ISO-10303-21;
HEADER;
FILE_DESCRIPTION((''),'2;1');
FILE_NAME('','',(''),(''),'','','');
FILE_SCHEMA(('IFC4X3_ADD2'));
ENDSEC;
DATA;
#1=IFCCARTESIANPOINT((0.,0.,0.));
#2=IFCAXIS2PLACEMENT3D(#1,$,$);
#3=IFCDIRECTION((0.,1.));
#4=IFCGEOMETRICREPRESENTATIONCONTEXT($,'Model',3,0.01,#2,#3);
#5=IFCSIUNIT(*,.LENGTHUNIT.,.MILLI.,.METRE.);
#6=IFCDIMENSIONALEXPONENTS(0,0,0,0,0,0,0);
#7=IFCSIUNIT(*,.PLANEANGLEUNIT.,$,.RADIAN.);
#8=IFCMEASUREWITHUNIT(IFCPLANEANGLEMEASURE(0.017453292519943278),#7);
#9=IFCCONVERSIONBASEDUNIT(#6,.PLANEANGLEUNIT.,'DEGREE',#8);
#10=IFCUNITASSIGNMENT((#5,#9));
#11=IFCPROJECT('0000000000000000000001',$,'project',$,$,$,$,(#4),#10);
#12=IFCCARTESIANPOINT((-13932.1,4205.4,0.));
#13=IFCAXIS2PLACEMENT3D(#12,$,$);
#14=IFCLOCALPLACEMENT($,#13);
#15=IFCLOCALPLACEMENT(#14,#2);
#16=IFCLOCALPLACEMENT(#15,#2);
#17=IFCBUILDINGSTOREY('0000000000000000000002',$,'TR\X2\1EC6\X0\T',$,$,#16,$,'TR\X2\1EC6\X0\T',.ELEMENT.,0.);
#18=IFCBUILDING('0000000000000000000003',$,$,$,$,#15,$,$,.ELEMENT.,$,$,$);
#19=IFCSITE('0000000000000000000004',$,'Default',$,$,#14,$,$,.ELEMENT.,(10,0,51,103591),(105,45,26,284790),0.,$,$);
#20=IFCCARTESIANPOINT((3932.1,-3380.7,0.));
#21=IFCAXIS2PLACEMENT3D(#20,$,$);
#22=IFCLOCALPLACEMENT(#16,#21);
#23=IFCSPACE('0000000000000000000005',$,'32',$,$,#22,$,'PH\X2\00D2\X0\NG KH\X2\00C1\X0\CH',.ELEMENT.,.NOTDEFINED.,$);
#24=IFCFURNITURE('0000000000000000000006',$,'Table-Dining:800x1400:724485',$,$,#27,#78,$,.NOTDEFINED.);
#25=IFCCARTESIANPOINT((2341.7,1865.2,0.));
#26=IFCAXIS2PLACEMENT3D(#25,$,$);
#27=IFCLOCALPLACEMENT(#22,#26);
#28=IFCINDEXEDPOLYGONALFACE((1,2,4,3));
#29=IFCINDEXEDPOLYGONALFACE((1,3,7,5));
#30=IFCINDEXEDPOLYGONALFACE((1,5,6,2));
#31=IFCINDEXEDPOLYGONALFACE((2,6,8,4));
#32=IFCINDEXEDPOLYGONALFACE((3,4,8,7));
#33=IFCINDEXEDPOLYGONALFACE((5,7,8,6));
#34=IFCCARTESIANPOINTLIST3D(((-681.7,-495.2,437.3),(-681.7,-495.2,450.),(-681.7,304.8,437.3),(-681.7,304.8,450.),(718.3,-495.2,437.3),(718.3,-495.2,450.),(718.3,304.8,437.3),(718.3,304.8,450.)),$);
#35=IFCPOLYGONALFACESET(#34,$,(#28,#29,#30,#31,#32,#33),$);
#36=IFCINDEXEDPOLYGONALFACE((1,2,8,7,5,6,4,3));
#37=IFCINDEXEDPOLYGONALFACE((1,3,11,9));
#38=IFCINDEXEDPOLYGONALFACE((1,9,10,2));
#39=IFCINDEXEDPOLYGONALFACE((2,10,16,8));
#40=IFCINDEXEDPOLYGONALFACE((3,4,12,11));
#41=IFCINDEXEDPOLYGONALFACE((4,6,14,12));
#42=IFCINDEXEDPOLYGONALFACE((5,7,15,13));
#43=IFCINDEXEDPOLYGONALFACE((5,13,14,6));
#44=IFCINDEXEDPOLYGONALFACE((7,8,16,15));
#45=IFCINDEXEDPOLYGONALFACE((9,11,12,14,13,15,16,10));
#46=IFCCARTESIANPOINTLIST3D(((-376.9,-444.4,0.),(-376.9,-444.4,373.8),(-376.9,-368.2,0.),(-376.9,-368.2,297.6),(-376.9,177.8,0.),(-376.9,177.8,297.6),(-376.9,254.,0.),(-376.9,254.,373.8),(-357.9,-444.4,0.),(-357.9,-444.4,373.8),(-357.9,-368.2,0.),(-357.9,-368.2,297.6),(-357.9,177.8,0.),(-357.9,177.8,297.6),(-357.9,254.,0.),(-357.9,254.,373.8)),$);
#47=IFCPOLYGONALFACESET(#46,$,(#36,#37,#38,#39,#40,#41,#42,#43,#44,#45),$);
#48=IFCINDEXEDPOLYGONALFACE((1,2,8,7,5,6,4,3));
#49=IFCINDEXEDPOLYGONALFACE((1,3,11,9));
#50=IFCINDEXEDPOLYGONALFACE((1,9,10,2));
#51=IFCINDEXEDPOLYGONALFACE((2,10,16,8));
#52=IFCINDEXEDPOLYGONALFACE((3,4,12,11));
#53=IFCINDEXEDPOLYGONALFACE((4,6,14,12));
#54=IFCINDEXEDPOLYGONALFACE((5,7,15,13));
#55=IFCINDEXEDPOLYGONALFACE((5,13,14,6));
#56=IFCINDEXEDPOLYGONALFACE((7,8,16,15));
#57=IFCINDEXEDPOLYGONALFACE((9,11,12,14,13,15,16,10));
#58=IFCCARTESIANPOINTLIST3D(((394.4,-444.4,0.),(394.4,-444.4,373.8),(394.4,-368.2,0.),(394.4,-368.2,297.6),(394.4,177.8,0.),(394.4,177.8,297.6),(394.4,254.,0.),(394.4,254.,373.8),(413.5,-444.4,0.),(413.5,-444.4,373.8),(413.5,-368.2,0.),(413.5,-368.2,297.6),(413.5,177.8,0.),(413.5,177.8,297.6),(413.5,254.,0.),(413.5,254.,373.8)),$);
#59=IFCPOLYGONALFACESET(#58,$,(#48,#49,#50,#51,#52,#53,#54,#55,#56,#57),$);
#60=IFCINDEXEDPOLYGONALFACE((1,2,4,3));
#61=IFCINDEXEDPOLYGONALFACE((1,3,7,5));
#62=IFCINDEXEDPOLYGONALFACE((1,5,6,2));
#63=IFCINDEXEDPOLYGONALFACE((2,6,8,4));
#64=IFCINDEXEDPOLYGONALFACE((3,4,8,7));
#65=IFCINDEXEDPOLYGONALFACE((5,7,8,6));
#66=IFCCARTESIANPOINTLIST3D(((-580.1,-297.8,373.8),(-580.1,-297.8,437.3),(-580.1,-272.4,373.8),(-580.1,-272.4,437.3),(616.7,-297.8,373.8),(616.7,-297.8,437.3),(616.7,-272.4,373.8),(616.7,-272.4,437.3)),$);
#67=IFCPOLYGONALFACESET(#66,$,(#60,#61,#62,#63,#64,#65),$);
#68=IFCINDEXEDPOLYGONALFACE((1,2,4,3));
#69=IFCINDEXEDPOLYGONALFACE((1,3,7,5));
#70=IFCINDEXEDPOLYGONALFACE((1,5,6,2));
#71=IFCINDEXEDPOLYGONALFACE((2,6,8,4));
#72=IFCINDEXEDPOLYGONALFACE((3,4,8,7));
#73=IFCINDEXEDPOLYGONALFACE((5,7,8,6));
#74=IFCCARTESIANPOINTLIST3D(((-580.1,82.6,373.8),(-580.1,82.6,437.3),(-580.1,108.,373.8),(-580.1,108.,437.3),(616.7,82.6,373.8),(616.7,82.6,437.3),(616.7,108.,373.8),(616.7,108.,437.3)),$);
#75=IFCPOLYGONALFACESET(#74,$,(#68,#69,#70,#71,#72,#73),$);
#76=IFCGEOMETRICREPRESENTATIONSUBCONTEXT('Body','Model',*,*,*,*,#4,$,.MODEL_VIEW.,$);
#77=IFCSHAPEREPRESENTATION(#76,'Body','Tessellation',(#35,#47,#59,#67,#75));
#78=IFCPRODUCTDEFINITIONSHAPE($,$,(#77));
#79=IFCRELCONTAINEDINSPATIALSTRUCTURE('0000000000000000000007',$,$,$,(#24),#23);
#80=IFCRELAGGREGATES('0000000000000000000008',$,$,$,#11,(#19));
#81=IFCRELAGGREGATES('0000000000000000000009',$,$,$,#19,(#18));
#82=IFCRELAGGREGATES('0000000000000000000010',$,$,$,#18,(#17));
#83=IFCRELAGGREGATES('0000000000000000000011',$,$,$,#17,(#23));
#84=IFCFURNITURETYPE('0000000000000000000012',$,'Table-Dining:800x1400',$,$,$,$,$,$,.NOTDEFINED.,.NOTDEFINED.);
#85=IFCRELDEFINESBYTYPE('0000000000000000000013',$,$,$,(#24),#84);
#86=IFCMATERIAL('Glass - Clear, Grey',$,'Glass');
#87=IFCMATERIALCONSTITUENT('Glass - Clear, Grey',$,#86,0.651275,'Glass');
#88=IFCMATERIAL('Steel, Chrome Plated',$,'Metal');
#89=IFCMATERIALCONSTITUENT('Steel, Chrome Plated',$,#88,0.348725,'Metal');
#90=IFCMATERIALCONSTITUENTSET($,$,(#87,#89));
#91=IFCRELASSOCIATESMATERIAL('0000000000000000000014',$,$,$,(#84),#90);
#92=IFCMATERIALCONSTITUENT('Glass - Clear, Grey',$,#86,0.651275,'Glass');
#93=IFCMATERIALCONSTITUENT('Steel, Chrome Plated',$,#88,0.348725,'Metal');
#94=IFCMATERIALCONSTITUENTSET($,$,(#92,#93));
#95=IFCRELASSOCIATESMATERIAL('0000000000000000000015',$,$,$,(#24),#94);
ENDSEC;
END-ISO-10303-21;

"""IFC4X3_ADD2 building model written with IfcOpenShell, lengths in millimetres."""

from ifc_helpers import new_model, entity, si_unit, converted_unit, direction, frame, frame_2d, origin, origin_2d_with_axis, place, context, subcontext, project, spatial, polyline, rectangle, outline, extrude, source, transform, mapped, material, constituent, constituent_set, type_object, type_shapes, element, save


model = new_model("IFC4X3_ADD2")

# Units and contexts
model_context = context("Model", 3, precision=0.01, world=origin(), true_north=direction((0.0, 1.0)))
body_context = subcontext(model_context, "Body", "Model", "MODEL_VIEW")
ifc_project = project(units=[si_unit("LENGTHUNIT", "METRE", prefix="MILLI"), converted_unit("PLANEANGLEUNIT", "DEGREE", entity("IfcPlaneAngleMeasure", 0.017453292519943278), si_unit("PLANEANGLEUNIT", "RADIAN"), dimensions=[0, 0, 0, 0, 0, 0, 0])], contexts=[model_context])

# Site, building, storey
site_placement = place(None, frame((-13932.1, 4205.4, 0.0)))
site = spatial("IfcSite", under=ifc_project, at=site_placement, Name="Default", CompositionType="ELEMENT", RefLatitude=(10, 0, 51, 103591), RefLongitude=(105, 45, 26, 284790), RefElevation=0.0)
building_placement = place(site_placement, origin())
building = spatial("IfcBuilding", under=site, at=building_placement, CompositionType="ELEMENT")
storey_placement = place(building_placement, origin())
storey = spatial("IfcBuildingStorey", under=building, at=storey_placement, Name="TRỆT", LongName="TRỆT", CompositionType="ELEMENT", Elevation=0.0)

# Shared definitions
space_1_placement = place(storey_placement, frame((3932.1, -3380.7, 0.0)))
space_1 = spatial("IfcSpace", under=storey, at=space_1_placement, Name="32", LongName="PHÒNG KHÁCH", CompositionType="ELEMENT", PredefinedType="NOTDEFINED")

# Furniture
ifc_material_1 = material(Name="Glass - Clear, Grey", Category="Glass")
ifc_constituent_1 = constituent(ifc_material_1, Name="Glass - Clear, Grey", Category="Glass", fraction=0.651275)
ifc_material_2 = material(Name="Steel, Chrome Plated", Category="Metal")
ifc_constituent_2 = constituent(ifc_material_2, Name="Steel, Chrome Plated", Category="Metal", fraction=0.348725)
ifc_constituent_set_1 = constituent_set(constituents=[ifc_constituent_1, ifc_constituent_2])
ifc_constituent_3 = constituent(ifc_material_1, Name="Glass - Clear, Grey", Category="Glass", fraction=0.651275)
ifc_constituent_4 = constituent(ifc_material_2, Name="Steel, Chrome Plated", Category="Metal", fraction=0.348725)
ifc_constituent_set_2 = constituent_set(constituents=[ifc_constituent_3, ifc_constituent_4])
furniture_type_1 = type_object("IfcFurnitureType", Name="Table-Dining:800x1400", AssemblyPlace="NOTDEFINED", PredefinedType="NOTDEFINED", material=ifc_constituent_set_2)
shared_shape_1 = source(origin(), body_context, "Body", "SweptSolid", [
    extrude(rectangle(XDim=800.0, YDim=1400.0, at=origin_2d_with_axis()), frame((18.3, -95.2, 437.3), z_axis=(0.0, 0.0, 1.0), x_axis=(0.0, 1.0, 0.0)), (0.0, 0.0, 1.0), 12.7),
    extrude(outline(polyline([(-205.9, -349.2), (167.8, -349.2), (167.8, -273.0), (-129.7, -273.0), (-129.7, 273.0), (167.8, 273.0), (167.8, 349.2), (-205.9, 349.2), (-205.9, -349.2)])), frame((-376.9, -95.2, 167.8), z_axis=(1.0, 0.0, 0.0), x_axis=(0.0, 0.0, -1.0)), (0.0, 0.0, 1.0), 19.1),
    extrude(outline(polyline([(-349.2, -167.8), (-273.0, -167.8), (-273.0, 129.7), (273.0, 129.7), (273.0, -167.8), (349.2, -167.8), (349.2, 205.9), (-349.2, 205.9), (-349.2, -167.8)])), frame((394.4, -95.2, 167.8), z_axis=(1.0, 0.0, 0.0), x_axis=(0.0, 1.0, 0.0)), (0.0, 0.0, 1.0), 19.1),
    extrude(rectangle(XDim=25.4, YDim=1196.8, at=frame_2d((0.0, 0.0), x_axis=(1.0, 0.0))), frame((18.3, -285.1, 373.8), z_axis=(0.0, 0.0, 1.0), x_axis=(0.0, 1.0, 0.0)), (0.0, 0.0, 1.0), 63.5),
    extrude(rectangle(XDim=25.4, YDim=1196.8, at=origin_2d_with_axis()), frame((18.3, 95.3, 373.8), z_axis=(0.0, 0.0, 1.0), x_axis=(0.0, 1.0, 0.0)), (0.0, 0.0, 1.0), 63.5),
])
type_shapes(furniture_type_1, [shared_shape_1])
furniture_1_placement = place(space_1_placement, frame((2341.7, 1865.2, 0.0)))
element("IfcFurniture", 1, at=furniture_1_placement, inside=space_1, type_object=furniture_type_1, material=ifc_constituent_set_1, Name="Table-Dining:800x1400:724485", PredefinedType="NOTDEFINED", context=body_context, shape_type="MappedRepresentation", body=[
    mapped(shared_shape_1, transform((0.0, 0.0, 0.0), scale=1.0)),
])

save(model, "model.ifc")
